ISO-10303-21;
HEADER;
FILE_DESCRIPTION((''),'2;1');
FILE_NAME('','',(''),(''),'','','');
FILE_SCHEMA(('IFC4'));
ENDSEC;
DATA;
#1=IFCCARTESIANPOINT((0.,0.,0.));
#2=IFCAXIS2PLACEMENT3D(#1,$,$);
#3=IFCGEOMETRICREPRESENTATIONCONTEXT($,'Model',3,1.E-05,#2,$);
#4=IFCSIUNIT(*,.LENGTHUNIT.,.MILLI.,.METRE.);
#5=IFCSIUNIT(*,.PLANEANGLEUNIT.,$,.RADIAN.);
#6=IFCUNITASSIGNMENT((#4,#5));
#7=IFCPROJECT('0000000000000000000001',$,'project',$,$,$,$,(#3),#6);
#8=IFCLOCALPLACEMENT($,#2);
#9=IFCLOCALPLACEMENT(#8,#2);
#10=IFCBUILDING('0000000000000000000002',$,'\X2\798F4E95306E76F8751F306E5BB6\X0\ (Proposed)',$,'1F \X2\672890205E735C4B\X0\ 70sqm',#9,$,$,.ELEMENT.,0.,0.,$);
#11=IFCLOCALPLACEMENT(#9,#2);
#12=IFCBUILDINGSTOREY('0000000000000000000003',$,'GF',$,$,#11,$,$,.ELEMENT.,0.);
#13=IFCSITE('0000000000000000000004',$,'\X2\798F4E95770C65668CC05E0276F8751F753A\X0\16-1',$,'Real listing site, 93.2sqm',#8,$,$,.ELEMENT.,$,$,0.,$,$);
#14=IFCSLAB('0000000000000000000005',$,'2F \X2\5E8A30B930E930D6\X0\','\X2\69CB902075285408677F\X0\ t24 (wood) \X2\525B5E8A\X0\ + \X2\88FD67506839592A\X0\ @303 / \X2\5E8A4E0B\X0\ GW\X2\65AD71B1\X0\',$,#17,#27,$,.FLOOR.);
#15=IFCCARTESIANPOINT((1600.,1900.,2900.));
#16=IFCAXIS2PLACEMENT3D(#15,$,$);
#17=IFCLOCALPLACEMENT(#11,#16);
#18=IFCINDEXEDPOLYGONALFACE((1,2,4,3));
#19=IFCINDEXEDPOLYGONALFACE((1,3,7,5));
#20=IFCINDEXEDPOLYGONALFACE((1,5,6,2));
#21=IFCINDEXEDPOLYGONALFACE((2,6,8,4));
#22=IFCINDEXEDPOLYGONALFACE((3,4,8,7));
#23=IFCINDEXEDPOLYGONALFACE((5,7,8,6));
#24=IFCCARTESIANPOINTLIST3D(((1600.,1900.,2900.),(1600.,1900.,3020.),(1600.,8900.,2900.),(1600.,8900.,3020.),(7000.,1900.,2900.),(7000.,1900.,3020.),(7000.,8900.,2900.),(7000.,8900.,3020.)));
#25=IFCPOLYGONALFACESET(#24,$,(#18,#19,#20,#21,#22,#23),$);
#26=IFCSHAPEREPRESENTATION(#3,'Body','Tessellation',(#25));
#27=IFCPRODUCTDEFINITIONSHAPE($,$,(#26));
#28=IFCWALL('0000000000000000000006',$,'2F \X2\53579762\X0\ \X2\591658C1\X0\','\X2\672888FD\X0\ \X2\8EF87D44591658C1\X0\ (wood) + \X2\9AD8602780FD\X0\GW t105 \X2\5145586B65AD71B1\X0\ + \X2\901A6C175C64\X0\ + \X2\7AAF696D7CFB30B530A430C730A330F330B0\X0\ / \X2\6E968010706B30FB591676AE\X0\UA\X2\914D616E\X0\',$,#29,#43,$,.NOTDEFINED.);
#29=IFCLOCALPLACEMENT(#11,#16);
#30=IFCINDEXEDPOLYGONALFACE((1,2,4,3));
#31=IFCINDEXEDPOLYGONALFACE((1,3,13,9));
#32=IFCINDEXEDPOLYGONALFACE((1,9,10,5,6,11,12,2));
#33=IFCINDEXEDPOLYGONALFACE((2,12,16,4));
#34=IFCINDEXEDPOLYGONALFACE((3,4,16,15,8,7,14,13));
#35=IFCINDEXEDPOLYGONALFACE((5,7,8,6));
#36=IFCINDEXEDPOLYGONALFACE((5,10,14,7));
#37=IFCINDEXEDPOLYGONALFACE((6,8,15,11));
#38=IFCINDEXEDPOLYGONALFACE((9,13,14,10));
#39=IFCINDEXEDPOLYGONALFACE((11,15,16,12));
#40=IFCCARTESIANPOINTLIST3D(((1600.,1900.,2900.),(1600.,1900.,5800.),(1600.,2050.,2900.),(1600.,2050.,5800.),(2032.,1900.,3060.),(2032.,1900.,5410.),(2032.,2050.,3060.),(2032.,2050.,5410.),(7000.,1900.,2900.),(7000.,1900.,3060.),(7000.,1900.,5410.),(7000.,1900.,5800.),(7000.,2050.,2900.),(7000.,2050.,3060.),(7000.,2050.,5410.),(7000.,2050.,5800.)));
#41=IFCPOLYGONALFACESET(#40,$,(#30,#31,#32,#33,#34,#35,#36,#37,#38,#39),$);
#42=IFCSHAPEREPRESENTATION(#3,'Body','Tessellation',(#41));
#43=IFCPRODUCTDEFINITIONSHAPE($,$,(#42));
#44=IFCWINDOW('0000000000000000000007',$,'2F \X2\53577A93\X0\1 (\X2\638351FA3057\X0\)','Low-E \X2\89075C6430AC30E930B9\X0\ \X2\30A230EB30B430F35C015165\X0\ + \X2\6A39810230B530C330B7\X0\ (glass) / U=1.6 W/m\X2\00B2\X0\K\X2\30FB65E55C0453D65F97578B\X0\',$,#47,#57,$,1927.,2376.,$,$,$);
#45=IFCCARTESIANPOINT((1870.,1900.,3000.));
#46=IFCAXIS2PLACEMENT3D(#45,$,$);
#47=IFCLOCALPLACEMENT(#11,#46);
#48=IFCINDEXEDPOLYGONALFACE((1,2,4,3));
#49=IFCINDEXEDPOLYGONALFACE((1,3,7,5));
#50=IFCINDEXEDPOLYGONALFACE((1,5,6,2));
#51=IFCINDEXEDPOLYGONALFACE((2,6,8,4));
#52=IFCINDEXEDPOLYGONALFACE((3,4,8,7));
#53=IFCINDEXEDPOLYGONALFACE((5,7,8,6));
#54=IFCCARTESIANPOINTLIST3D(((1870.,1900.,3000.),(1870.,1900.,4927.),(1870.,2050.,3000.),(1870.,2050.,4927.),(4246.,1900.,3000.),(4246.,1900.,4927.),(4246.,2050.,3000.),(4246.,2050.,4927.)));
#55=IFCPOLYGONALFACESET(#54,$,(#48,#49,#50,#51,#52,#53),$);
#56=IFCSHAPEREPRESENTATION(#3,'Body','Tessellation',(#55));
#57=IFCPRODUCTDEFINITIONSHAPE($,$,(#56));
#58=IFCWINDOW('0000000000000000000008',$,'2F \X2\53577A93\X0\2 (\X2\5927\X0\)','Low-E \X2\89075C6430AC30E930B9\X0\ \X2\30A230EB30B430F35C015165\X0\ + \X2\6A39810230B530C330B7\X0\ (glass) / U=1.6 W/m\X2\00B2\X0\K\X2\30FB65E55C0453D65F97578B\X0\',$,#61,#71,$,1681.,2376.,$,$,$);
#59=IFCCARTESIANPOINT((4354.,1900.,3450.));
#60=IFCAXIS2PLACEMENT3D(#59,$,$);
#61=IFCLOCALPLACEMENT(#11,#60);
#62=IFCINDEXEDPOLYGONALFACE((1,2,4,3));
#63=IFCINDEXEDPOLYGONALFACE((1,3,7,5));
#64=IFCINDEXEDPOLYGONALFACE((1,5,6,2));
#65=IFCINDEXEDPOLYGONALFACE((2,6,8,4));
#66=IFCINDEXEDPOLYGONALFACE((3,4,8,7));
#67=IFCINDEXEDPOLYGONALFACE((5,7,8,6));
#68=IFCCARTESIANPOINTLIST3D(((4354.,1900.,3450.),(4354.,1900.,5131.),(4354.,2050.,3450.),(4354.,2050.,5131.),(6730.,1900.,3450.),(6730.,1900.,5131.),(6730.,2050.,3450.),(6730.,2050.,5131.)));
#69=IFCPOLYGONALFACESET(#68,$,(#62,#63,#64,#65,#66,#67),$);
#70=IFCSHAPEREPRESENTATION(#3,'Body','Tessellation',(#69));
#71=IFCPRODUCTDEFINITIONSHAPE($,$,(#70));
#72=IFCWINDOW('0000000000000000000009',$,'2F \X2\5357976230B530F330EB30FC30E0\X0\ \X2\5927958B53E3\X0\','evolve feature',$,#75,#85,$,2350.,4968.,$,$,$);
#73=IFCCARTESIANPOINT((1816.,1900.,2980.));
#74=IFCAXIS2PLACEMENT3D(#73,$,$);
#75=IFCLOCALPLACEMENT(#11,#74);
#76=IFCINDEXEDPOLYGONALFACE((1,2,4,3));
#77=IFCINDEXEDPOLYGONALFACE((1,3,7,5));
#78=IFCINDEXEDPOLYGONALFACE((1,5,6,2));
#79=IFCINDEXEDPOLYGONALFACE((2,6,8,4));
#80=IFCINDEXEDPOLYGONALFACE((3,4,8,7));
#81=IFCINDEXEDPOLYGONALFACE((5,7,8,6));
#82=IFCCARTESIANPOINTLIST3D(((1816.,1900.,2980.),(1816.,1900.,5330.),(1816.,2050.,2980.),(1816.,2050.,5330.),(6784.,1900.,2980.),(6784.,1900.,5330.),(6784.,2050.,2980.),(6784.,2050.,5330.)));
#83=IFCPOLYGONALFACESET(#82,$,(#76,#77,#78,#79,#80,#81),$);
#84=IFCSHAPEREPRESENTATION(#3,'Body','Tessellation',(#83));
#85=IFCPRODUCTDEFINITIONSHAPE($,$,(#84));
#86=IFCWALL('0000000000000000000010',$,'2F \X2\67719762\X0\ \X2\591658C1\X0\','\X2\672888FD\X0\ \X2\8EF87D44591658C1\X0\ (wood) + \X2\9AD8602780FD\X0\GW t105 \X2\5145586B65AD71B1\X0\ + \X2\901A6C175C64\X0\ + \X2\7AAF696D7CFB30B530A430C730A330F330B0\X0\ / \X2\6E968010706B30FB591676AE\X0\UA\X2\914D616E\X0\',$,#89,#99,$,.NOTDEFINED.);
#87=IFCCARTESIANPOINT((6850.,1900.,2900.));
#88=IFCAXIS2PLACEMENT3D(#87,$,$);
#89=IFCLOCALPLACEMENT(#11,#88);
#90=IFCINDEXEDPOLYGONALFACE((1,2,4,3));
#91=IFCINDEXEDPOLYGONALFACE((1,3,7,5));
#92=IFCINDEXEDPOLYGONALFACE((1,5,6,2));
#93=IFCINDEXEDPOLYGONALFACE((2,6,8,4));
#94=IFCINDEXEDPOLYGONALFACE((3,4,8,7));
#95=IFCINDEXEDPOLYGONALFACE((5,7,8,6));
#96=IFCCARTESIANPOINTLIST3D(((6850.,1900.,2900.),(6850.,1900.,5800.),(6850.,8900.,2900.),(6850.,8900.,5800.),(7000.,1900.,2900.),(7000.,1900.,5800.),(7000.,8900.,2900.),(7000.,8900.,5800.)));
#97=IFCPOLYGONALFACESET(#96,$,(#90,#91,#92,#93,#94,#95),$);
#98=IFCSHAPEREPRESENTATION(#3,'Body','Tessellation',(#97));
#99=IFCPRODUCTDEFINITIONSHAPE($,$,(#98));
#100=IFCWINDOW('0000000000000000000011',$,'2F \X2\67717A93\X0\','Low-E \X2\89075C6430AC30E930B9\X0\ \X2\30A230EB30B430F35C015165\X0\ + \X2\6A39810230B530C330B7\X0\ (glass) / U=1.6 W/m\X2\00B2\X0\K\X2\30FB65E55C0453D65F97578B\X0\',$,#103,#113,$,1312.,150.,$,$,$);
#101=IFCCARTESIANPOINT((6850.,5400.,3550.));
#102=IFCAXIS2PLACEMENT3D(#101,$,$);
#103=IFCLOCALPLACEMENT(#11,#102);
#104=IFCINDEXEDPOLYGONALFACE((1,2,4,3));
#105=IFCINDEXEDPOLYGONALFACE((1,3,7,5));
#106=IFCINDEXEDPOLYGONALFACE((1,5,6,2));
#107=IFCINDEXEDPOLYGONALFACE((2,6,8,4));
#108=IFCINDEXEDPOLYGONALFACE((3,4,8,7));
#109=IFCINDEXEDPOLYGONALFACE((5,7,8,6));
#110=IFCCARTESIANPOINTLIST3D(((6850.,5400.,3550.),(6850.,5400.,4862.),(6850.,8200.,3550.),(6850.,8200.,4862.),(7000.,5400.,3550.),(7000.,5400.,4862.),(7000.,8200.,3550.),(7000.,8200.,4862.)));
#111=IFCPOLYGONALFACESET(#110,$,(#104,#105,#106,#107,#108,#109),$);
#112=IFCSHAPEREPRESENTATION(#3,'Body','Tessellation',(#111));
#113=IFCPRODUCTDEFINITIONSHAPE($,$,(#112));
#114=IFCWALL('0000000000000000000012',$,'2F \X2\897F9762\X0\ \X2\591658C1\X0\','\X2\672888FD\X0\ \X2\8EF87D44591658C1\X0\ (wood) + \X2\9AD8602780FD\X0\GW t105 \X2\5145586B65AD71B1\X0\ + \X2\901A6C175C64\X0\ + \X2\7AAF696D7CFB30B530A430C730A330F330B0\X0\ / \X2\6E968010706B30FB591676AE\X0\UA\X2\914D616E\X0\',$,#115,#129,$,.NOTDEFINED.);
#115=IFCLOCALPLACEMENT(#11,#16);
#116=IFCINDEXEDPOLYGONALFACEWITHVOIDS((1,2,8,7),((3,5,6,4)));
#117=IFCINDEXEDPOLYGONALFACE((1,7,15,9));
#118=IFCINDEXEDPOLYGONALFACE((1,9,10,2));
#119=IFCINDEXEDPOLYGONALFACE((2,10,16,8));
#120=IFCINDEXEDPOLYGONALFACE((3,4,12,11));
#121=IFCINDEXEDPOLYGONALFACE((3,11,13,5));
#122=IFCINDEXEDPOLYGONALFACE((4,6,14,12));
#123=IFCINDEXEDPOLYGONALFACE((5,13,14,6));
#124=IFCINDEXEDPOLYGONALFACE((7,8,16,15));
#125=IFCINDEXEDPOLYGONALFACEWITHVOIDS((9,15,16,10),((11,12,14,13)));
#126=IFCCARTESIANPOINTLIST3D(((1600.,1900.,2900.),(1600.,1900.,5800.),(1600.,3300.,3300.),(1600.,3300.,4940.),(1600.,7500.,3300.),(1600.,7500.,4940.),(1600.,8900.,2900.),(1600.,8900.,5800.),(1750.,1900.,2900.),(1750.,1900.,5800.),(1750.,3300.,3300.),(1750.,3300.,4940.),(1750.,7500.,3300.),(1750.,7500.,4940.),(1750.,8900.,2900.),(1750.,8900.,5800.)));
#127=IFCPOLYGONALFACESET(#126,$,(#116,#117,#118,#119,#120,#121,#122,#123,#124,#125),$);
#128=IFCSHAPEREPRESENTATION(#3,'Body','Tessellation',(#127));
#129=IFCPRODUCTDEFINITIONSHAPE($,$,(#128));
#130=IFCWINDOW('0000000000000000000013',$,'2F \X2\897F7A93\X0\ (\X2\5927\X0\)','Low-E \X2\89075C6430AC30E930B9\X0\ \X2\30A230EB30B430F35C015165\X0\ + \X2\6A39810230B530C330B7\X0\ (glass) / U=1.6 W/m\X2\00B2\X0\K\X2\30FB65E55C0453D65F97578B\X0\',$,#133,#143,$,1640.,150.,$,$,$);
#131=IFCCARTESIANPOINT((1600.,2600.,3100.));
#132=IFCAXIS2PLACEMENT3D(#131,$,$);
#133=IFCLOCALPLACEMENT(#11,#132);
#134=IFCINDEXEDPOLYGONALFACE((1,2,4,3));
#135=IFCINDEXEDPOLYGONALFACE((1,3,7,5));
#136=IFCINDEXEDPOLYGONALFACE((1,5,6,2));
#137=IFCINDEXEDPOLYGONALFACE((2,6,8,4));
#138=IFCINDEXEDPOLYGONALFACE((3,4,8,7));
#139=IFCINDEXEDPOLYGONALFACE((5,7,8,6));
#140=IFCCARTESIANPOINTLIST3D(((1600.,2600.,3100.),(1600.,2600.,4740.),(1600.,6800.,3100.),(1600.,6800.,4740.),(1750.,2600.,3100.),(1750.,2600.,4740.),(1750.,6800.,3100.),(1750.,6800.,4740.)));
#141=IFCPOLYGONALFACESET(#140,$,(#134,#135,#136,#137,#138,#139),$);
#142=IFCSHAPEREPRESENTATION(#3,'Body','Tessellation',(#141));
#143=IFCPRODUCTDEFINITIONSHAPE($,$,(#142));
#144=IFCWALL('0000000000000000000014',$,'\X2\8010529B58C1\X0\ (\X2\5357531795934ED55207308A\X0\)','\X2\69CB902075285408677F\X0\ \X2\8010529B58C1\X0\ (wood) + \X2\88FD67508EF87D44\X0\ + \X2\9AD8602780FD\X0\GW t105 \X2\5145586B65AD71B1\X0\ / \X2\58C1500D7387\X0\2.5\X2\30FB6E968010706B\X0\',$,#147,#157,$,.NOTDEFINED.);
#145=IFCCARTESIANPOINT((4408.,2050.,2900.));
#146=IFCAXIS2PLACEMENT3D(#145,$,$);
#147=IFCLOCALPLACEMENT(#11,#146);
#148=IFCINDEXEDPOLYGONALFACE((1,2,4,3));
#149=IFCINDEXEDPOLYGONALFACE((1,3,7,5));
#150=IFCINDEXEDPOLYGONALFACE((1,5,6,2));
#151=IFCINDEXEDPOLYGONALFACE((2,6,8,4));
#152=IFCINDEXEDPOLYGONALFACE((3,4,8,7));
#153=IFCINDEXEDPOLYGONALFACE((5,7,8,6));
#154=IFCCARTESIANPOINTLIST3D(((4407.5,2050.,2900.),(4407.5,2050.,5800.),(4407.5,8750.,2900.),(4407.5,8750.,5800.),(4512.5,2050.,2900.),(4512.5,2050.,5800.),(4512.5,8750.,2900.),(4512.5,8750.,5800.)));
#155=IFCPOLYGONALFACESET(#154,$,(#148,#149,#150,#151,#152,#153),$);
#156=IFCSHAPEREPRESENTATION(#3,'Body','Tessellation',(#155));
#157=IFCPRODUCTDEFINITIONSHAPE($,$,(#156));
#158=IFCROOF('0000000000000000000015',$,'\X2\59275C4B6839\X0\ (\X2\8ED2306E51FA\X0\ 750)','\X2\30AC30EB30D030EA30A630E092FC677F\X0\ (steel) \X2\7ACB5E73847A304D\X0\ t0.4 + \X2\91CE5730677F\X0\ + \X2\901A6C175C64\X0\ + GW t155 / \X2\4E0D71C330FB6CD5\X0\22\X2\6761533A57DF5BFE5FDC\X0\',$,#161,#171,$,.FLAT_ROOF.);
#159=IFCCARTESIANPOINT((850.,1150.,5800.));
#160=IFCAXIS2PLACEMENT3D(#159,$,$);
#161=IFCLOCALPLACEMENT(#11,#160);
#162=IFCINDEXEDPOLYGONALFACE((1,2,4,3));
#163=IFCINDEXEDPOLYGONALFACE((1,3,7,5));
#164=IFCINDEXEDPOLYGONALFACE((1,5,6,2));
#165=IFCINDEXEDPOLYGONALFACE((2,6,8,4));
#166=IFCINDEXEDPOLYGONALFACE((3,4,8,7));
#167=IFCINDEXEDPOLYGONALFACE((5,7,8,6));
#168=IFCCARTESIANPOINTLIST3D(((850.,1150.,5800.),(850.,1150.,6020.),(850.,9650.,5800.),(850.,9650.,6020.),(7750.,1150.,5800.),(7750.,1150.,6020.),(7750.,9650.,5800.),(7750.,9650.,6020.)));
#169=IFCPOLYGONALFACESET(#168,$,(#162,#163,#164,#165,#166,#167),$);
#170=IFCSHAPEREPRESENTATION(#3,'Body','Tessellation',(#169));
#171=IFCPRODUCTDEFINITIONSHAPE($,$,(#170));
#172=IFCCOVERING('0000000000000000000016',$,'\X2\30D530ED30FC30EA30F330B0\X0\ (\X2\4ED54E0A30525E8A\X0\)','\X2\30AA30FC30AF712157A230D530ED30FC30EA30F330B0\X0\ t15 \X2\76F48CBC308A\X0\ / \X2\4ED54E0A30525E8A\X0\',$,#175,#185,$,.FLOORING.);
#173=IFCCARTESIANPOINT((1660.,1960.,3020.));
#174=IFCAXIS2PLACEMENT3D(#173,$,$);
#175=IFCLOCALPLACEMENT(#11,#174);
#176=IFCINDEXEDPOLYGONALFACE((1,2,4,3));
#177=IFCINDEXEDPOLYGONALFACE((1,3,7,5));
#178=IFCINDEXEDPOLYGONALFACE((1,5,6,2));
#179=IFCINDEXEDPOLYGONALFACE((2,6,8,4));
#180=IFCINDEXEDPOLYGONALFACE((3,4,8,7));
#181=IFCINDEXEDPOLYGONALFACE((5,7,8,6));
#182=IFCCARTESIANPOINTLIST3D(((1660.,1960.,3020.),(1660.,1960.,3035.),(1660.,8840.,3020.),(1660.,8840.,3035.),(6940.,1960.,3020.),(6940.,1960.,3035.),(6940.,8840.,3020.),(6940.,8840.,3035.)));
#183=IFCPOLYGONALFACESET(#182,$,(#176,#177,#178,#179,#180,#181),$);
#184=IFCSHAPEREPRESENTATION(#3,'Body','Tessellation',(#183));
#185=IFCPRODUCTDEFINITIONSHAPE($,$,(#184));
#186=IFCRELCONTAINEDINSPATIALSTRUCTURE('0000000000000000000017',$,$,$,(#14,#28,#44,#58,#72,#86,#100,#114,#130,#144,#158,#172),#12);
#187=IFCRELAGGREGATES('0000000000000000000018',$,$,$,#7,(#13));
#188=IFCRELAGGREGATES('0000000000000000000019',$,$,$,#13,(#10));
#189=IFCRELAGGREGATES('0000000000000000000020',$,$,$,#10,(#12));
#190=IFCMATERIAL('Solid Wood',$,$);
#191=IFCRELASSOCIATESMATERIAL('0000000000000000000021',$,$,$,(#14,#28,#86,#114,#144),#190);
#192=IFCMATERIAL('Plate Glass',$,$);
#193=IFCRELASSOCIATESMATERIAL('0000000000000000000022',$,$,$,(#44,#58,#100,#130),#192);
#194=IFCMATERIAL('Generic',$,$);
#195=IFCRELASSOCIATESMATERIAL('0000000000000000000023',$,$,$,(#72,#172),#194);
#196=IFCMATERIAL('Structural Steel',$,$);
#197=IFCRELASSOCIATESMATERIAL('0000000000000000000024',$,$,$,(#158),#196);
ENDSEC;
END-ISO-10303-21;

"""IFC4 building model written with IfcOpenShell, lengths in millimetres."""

from ifc_helpers import new_model, si_unit, frame, frame_2d, origin, place, context, project, spatial, rectangle, extrude, material, element, fill, save


model = new_model("IFC4")

# Units and contexts
model_context = context("Model", 3, precision=1e-05, world=origin())
ifc_project = project(units=[si_unit("LENGTHUNIT", "METRE", prefix="MILLI"), si_unit("PLANEANGLEUNIT", "RADIAN")], contexts=[model_context])

# Site, building, storey
site_placement = place(None, origin())
site = spatial("IfcSite", under=ifc_project, at=site_placement, Name="福井県敦賀市相生町16-1", ObjectType="Real listing site, 93.2sqm", CompositionType="ELEMENT", RefElevation=0.0)
building_placement = place(site_placement, origin())
building = spatial("IfcBuilding", under=site, at=building_placement, Name="福井の相生の家 (Proposed)", ObjectType="1F 木造平屋 70sqm", CompositionType="ELEMENT", ElevationOfRefHeight=0.0, ElevationOfTerrain=0.0)
storey_placement = place(building_placement, origin())
storey = spatial("IfcBuildingStorey", under=building, at=storey_placement, Name="GF", CompositionType="ELEMENT", Elevation=0.0)

# Slab
ifc_material_1 = material(Name="Solid Wood")
slab_placement = place(storey_placement, frame((1600.0, 1900.0, 2900.0)))
element("IfcSlab", 1, at=slab_placement, inside=storey, material=ifc_material_1, Name="2F 床スラブ", Description="構造用合板 t24 (wood) 剛床 + 製材根太 @303 / 床下 GW断熱", PredefinedType="FLOOR", context=model_context, shape_type="SweptSolid", body=[
    extrude(rectangle(XDim=5400.0, YDim=7000.0, at=frame_2d((2700.0, 3500.0))), frame((1600.0, 1900.0, 2900.0)), (0.0, 0.0, 1.0), 120.0),
])

# Wall, openings, windows
wall_1_placement = place(storey_placement, frame((1600.0, 1900.0, 2900.0)))
wall_1 = element("IfcWall", 2, at=wall_1_placement, inside=storey, material=ifc_material_1, Name="2F 南面 外壁", Description="木製 軸組外壁 (wood) + 高性能GW t105 充填断熱 + 通気層 + 窯業系サイディング / 準耐火・外皮UA配慮", PredefinedType="NOTDEFINED", context=model_context, shape_type="SweptSolid", body=[
    extrude(rectangle(XDim=5400.0, YDim=150.0, at=frame_2d((2700.0, 75.0))), frame((1600.0, 1900.0, 2900.0)), (0.0, 0.0, 1.0), 2900.0),
])
opening_1_placement = place(storey_placement, frame((1870.0, 1900.0, 3000.0)))
opening_1 = element("IfcOpeningElement", 3, at=opening_1_placement, cuts=wall_1, PredefinedType="NOTDEFINED", context=model_context, shape_type="SweptSolid", body=[
    extrude(rectangle(XDim=2376.0, YDim=150.0, at=frame_2d((1188.0, 75.0))), frame((1870.0, 1900.0, 3000.0)), (0.0, 0.0, 1.0), 1927.0),
])
opening_2_placement = place(storey_placement, frame((4354.0, 1900.0, 3450.0)))
opening_2 = element("IfcOpeningElement", 4, at=opening_2_placement, cuts=wall_1, PredefinedType="NOTDEFINED", context=model_context, shape_type="SweptSolid", body=[
    extrude(rectangle(XDim=2376.0, YDim=150.0, at=frame_2d((1188.0, 75.0))), frame((4354.0, 1900.0, 3450.0)), (0.0, 0.0, 1.0), 1681.0),
])
opening_3_placement = place(storey_placement, frame((1816.0, 1900.0, 2980.0)))
opening_3 = element("IfcOpeningElement", 5, at=opening_3_placement, cuts=wall_1, PredefinedType="NOTDEFINED", context=model_context, shape_type="SweptSolid", body=[
    extrude(rectangle(XDim=4968.0, YDim=150.0, at=frame_2d((2484.0, 75.0))), frame((1816.0, 1900.0, 2980.0)), (0.0, 0.0, 1.0), 2350.0),
])
ifc_material_2 = material(Name="Plate Glass")
window_1_placement = place(storey_placement, frame((1870.0, 1900.0, 3000.0)))
window_1 = element("IfcWindow", 6, at=window_1_placement, inside=storey, material=ifc_material_2, Name="2F 南窓1 (掃出し)", Description="Low-E 複層ガラス アルゴン封入 + 樹脂サッシ (glass) / U=1.6 W/m²K・日射取得型", OverallHeight=1927.0, OverallWidth=2376.0, context=model_context, shape_type="SweptSolid", body=[
    extrude(rectangle(XDim=2376.0, YDim=150.0, at=frame_2d((1188.0, 75.0))), frame((1870.0, 1900.0, 3000.0)), (0.0, 0.0, 1.0), 1927.0),
])
fill(opening_1, window_1)
window_2_placement = place(storey_placement, frame((4354.0, 1900.0, 3450.0)))
window_2 = element("IfcWindow", 7, at=window_2_placement, inside=storey, material=ifc_material_2, Name="2F 南窓2 (大)", Description="Low-E 複層ガラス アルゴン封入 + 樹脂サッシ (glass) / U=1.6 W/m²K・日射取得型", OverallHeight=1681.0, OverallWidth=2376.0, context=model_context, shape_type="SweptSolid", body=[
    extrude(rectangle(XDim=2376.0, YDim=150.0, at=frame_2d((1188.0, 75.0))), frame((4354.0, 1900.0, 3450.0)), (0.0, 0.0, 1.0), 1681.0),
])
fill(opening_2, window_2)
ifc_material_3 = material(Name="Generic")
window_3_placement = place(storey_placement, frame((1816.0, 1900.0, 2980.0)))
window_3 = element("IfcWindow", 8, at=window_3_placement, inside=storey, material=ifc_material_3, Name="2F 南面サンルーム 大開口", Description="evolve feature", OverallHeight=2350.0, OverallWidth=4968.0, context=model_context, shape_type="SweptSolid", body=[
    extrude(rectangle(XDim=4968.0, YDim=150.0, at=frame_2d((2484.0, 75.0))), frame((1816.0, 1900.0, 2980.0)), (0.0, 0.0, 1.0), 2350.0),
])
fill(opening_3, window_3)

# Walls, openings, windows
wall_2_placement = place(storey_placement, frame((6850.0, 1900.0, 2900.0)))
wall_2 = element("IfcWall", 9, at=wall_2_placement, inside=storey, material=ifc_material_1, Name="2F 東面 外壁", Description="木製 軸組外壁 (wood) + 高性能GW t105 充填断熱 + 通気層 + 窯業系サイディング / 準耐火・外皮UA配慮", PredefinedType="NOTDEFINED", context=model_context, shape_type="SweptSolid", body=[
    extrude(rectangle(XDim=150.0, YDim=7000.0, at=frame_2d((75.0, 3500.0))), frame((6850.0, 1900.0, 2900.0)), (0.0, 0.0, 1.0), 2900.0),
])
opening_4_placement = place(storey_placement, frame((6850.0, 5400.0, 3550.0)))
opening_4 = element("IfcOpeningElement", 10, at=opening_4_placement, cuts=wall_2, PredefinedType="NOTDEFINED", context=model_context, shape_type="SweptSolid", body=[
    extrude(rectangle(XDim=150.0, YDim=2800.0, at=frame_2d((75.0, 1400.0))), frame((6850.0, 5400.0, 3550.0)), (0.0, 0.0, 1.0), 1312.0),
])
window_4_placement = place(storey_placement, frame((6850.0, 5400.0, 3550.0)))
window_4 = element("IfcWindow", 11, at=window_4_placement, inside=storey, material=ifc_material_2, Name="2F 東窓", Description="Low-E 複層ガラス アルゴン封入 + 樹脂サッシ (glass) / U=1.6 W/m²K・日射取得型", OverallHeight=1312.0, OverallWidth=150.0, context=model_context, shape_type="SweptSolid", body=[
    extrude(rectangle(XDim=150.0, YDim=2800.0, at=frame_2d((75.0, 1400.0))), frame((6850.0, 5400.0, 3550.0)), (0.0, 0.0, 1.0), 1312.0),
])
fill(opening_4, window_4)
wall_3_placement = place(storey_placement, frame((1600.0, 1900.0, 2900.0)))
wall_3 = element("IfcWall", 12, at=wall_3_placement, inside=storey, material=ifc_material_1, Name="2F 西面 外壁", Description="木製 軸組外壁 (wood) + 高性能GW t105 充填断熱 + 通気層 + 窯業系サイディング / 準耐火・外皮UA配慮", PredefinedType="NOTDEFINED", context=model_context, shape_type="SweptSolid", body=[
    extrude(rectangle(XDim=150.0, YDim=7000.0, at=frame_2d((75.0, 3500.0))), frame((1600.0, 1900.0, 2900.0)), (0.0, 0.0, 1.0), 2900.0),
])
opening_5_placement = place(storey_placement, frame((1600.0, 2600.0, 3100.0)))
opening_5 = element("IfcOpeningElement", 13, at=opening_5_placement, cuts=wall_3, PredefinedType="NOTDEFINED", context=model_context, shape_type="SweptSolid", body=[
    extrude(rectangle(XDim=150.0, YDim=4200.0, at=frame_2d((75.0, 2100.0))), frame((1600.0, 2600.0, 3100.0)), (0.0, 0.0, 1.0), 1640.0),
])
window_5_placement = place(storey_placement, frame((1600.0, 2600.0, 3100.0)))
window_5 = element("IfcWindow", 14, at=window_5_placement, inside=storey, material=ifc_material_2, Name="2F 西窓 (大)", Description="Low-E 複層ガラス アルゴン封入 + 樹脂サッシ (glass) / U=1.6 W/m²K・日射取得型", OverallHeight=1640.0, OverallWidth=150.0, context=model_context, shape_type="SweptSolid", body=[
    extrude(rectangle(XDim=150.0, YDim=4200.0, at=frame_2d((75.0, 2100.0))), frame((1600.0, 2600.0, 3100.0)), (0.0, 0.0, 1.0), 1640.0),
])
fill(opening_5, window_5)

# Wall
wall_4_placement = place(storey_placement, frame((4408.0, 2050.0, 2900.0)))
element("IfcWall", 15, at=wall_4_placement, inside=storey, material=ifc_material_1, Name="耐力壁 (南北間仕切り)", Description="構造用合板 耐力壁 (wood) + 製材軸組 + 高性能GW t105 充填断熱 / 壁倍率2.5・準耐火", PredefinedType="NOTDEFINED", context=model_context, shape_type="SweptSolid", body=[
    extrude(rectangle(XDim=105.0, YDim=6700.0, at=frame_2d((52.0, 3350.0))), frame((4408.0, 2050.0, 2900.0)), (0.0, 0.0, 1.0), 2900.0),
])

# Roof
ifc_material_4 = material(Name="Structural Steel")
roof_placement = place(storey_placement, frame((850.0, 1150.0, 5800.0)))
element("IfcRoof", 16, at=roof_placement, inside=storey, material=ifc_material_4, Name="大屋根 (軒の出 750)", Description="ガルバリウム鋼板 (steel) 立平葺き t0.4 + 野地板 + 通気層 + GW t155 / 不燃・法22条区域対応", PredefinedType="FLAT_ROOF", context=model_context, shape_type="SweptSolid", body=[
    extrude(rectangle(XDim=6900.0, YDim=8500.0, at=frame_2d((3450.0, 4250.0))), frame((850.0, 1150.0, 5800.0)), (0.0, 0.0, 1.0), 220.0),
])

# Covering
covering_placement = place(storey_placement, frame((1660.0, 1960.0, 3020.0)))
element("IfcCovering", 17, at=covering_placement, inside=storey, material=ifc_material_3, Name="フローリング (仕上げ床)", Description="オーク無垢フローリング t15 直貼り / 仕上げ床", PredefinedType="FLOORING", context=model_context, shape_type="SweptSolid", body=[
    extrude(rectangle(XDim=5280.0, YDim=6880.0, at=frame_2d((2640.0, 3440.0))), frame((1660.0, 1960.0, 3020.0)), (0.0, 0.0, 1.0), 15.0),
])

save(model, "model.ifc")
